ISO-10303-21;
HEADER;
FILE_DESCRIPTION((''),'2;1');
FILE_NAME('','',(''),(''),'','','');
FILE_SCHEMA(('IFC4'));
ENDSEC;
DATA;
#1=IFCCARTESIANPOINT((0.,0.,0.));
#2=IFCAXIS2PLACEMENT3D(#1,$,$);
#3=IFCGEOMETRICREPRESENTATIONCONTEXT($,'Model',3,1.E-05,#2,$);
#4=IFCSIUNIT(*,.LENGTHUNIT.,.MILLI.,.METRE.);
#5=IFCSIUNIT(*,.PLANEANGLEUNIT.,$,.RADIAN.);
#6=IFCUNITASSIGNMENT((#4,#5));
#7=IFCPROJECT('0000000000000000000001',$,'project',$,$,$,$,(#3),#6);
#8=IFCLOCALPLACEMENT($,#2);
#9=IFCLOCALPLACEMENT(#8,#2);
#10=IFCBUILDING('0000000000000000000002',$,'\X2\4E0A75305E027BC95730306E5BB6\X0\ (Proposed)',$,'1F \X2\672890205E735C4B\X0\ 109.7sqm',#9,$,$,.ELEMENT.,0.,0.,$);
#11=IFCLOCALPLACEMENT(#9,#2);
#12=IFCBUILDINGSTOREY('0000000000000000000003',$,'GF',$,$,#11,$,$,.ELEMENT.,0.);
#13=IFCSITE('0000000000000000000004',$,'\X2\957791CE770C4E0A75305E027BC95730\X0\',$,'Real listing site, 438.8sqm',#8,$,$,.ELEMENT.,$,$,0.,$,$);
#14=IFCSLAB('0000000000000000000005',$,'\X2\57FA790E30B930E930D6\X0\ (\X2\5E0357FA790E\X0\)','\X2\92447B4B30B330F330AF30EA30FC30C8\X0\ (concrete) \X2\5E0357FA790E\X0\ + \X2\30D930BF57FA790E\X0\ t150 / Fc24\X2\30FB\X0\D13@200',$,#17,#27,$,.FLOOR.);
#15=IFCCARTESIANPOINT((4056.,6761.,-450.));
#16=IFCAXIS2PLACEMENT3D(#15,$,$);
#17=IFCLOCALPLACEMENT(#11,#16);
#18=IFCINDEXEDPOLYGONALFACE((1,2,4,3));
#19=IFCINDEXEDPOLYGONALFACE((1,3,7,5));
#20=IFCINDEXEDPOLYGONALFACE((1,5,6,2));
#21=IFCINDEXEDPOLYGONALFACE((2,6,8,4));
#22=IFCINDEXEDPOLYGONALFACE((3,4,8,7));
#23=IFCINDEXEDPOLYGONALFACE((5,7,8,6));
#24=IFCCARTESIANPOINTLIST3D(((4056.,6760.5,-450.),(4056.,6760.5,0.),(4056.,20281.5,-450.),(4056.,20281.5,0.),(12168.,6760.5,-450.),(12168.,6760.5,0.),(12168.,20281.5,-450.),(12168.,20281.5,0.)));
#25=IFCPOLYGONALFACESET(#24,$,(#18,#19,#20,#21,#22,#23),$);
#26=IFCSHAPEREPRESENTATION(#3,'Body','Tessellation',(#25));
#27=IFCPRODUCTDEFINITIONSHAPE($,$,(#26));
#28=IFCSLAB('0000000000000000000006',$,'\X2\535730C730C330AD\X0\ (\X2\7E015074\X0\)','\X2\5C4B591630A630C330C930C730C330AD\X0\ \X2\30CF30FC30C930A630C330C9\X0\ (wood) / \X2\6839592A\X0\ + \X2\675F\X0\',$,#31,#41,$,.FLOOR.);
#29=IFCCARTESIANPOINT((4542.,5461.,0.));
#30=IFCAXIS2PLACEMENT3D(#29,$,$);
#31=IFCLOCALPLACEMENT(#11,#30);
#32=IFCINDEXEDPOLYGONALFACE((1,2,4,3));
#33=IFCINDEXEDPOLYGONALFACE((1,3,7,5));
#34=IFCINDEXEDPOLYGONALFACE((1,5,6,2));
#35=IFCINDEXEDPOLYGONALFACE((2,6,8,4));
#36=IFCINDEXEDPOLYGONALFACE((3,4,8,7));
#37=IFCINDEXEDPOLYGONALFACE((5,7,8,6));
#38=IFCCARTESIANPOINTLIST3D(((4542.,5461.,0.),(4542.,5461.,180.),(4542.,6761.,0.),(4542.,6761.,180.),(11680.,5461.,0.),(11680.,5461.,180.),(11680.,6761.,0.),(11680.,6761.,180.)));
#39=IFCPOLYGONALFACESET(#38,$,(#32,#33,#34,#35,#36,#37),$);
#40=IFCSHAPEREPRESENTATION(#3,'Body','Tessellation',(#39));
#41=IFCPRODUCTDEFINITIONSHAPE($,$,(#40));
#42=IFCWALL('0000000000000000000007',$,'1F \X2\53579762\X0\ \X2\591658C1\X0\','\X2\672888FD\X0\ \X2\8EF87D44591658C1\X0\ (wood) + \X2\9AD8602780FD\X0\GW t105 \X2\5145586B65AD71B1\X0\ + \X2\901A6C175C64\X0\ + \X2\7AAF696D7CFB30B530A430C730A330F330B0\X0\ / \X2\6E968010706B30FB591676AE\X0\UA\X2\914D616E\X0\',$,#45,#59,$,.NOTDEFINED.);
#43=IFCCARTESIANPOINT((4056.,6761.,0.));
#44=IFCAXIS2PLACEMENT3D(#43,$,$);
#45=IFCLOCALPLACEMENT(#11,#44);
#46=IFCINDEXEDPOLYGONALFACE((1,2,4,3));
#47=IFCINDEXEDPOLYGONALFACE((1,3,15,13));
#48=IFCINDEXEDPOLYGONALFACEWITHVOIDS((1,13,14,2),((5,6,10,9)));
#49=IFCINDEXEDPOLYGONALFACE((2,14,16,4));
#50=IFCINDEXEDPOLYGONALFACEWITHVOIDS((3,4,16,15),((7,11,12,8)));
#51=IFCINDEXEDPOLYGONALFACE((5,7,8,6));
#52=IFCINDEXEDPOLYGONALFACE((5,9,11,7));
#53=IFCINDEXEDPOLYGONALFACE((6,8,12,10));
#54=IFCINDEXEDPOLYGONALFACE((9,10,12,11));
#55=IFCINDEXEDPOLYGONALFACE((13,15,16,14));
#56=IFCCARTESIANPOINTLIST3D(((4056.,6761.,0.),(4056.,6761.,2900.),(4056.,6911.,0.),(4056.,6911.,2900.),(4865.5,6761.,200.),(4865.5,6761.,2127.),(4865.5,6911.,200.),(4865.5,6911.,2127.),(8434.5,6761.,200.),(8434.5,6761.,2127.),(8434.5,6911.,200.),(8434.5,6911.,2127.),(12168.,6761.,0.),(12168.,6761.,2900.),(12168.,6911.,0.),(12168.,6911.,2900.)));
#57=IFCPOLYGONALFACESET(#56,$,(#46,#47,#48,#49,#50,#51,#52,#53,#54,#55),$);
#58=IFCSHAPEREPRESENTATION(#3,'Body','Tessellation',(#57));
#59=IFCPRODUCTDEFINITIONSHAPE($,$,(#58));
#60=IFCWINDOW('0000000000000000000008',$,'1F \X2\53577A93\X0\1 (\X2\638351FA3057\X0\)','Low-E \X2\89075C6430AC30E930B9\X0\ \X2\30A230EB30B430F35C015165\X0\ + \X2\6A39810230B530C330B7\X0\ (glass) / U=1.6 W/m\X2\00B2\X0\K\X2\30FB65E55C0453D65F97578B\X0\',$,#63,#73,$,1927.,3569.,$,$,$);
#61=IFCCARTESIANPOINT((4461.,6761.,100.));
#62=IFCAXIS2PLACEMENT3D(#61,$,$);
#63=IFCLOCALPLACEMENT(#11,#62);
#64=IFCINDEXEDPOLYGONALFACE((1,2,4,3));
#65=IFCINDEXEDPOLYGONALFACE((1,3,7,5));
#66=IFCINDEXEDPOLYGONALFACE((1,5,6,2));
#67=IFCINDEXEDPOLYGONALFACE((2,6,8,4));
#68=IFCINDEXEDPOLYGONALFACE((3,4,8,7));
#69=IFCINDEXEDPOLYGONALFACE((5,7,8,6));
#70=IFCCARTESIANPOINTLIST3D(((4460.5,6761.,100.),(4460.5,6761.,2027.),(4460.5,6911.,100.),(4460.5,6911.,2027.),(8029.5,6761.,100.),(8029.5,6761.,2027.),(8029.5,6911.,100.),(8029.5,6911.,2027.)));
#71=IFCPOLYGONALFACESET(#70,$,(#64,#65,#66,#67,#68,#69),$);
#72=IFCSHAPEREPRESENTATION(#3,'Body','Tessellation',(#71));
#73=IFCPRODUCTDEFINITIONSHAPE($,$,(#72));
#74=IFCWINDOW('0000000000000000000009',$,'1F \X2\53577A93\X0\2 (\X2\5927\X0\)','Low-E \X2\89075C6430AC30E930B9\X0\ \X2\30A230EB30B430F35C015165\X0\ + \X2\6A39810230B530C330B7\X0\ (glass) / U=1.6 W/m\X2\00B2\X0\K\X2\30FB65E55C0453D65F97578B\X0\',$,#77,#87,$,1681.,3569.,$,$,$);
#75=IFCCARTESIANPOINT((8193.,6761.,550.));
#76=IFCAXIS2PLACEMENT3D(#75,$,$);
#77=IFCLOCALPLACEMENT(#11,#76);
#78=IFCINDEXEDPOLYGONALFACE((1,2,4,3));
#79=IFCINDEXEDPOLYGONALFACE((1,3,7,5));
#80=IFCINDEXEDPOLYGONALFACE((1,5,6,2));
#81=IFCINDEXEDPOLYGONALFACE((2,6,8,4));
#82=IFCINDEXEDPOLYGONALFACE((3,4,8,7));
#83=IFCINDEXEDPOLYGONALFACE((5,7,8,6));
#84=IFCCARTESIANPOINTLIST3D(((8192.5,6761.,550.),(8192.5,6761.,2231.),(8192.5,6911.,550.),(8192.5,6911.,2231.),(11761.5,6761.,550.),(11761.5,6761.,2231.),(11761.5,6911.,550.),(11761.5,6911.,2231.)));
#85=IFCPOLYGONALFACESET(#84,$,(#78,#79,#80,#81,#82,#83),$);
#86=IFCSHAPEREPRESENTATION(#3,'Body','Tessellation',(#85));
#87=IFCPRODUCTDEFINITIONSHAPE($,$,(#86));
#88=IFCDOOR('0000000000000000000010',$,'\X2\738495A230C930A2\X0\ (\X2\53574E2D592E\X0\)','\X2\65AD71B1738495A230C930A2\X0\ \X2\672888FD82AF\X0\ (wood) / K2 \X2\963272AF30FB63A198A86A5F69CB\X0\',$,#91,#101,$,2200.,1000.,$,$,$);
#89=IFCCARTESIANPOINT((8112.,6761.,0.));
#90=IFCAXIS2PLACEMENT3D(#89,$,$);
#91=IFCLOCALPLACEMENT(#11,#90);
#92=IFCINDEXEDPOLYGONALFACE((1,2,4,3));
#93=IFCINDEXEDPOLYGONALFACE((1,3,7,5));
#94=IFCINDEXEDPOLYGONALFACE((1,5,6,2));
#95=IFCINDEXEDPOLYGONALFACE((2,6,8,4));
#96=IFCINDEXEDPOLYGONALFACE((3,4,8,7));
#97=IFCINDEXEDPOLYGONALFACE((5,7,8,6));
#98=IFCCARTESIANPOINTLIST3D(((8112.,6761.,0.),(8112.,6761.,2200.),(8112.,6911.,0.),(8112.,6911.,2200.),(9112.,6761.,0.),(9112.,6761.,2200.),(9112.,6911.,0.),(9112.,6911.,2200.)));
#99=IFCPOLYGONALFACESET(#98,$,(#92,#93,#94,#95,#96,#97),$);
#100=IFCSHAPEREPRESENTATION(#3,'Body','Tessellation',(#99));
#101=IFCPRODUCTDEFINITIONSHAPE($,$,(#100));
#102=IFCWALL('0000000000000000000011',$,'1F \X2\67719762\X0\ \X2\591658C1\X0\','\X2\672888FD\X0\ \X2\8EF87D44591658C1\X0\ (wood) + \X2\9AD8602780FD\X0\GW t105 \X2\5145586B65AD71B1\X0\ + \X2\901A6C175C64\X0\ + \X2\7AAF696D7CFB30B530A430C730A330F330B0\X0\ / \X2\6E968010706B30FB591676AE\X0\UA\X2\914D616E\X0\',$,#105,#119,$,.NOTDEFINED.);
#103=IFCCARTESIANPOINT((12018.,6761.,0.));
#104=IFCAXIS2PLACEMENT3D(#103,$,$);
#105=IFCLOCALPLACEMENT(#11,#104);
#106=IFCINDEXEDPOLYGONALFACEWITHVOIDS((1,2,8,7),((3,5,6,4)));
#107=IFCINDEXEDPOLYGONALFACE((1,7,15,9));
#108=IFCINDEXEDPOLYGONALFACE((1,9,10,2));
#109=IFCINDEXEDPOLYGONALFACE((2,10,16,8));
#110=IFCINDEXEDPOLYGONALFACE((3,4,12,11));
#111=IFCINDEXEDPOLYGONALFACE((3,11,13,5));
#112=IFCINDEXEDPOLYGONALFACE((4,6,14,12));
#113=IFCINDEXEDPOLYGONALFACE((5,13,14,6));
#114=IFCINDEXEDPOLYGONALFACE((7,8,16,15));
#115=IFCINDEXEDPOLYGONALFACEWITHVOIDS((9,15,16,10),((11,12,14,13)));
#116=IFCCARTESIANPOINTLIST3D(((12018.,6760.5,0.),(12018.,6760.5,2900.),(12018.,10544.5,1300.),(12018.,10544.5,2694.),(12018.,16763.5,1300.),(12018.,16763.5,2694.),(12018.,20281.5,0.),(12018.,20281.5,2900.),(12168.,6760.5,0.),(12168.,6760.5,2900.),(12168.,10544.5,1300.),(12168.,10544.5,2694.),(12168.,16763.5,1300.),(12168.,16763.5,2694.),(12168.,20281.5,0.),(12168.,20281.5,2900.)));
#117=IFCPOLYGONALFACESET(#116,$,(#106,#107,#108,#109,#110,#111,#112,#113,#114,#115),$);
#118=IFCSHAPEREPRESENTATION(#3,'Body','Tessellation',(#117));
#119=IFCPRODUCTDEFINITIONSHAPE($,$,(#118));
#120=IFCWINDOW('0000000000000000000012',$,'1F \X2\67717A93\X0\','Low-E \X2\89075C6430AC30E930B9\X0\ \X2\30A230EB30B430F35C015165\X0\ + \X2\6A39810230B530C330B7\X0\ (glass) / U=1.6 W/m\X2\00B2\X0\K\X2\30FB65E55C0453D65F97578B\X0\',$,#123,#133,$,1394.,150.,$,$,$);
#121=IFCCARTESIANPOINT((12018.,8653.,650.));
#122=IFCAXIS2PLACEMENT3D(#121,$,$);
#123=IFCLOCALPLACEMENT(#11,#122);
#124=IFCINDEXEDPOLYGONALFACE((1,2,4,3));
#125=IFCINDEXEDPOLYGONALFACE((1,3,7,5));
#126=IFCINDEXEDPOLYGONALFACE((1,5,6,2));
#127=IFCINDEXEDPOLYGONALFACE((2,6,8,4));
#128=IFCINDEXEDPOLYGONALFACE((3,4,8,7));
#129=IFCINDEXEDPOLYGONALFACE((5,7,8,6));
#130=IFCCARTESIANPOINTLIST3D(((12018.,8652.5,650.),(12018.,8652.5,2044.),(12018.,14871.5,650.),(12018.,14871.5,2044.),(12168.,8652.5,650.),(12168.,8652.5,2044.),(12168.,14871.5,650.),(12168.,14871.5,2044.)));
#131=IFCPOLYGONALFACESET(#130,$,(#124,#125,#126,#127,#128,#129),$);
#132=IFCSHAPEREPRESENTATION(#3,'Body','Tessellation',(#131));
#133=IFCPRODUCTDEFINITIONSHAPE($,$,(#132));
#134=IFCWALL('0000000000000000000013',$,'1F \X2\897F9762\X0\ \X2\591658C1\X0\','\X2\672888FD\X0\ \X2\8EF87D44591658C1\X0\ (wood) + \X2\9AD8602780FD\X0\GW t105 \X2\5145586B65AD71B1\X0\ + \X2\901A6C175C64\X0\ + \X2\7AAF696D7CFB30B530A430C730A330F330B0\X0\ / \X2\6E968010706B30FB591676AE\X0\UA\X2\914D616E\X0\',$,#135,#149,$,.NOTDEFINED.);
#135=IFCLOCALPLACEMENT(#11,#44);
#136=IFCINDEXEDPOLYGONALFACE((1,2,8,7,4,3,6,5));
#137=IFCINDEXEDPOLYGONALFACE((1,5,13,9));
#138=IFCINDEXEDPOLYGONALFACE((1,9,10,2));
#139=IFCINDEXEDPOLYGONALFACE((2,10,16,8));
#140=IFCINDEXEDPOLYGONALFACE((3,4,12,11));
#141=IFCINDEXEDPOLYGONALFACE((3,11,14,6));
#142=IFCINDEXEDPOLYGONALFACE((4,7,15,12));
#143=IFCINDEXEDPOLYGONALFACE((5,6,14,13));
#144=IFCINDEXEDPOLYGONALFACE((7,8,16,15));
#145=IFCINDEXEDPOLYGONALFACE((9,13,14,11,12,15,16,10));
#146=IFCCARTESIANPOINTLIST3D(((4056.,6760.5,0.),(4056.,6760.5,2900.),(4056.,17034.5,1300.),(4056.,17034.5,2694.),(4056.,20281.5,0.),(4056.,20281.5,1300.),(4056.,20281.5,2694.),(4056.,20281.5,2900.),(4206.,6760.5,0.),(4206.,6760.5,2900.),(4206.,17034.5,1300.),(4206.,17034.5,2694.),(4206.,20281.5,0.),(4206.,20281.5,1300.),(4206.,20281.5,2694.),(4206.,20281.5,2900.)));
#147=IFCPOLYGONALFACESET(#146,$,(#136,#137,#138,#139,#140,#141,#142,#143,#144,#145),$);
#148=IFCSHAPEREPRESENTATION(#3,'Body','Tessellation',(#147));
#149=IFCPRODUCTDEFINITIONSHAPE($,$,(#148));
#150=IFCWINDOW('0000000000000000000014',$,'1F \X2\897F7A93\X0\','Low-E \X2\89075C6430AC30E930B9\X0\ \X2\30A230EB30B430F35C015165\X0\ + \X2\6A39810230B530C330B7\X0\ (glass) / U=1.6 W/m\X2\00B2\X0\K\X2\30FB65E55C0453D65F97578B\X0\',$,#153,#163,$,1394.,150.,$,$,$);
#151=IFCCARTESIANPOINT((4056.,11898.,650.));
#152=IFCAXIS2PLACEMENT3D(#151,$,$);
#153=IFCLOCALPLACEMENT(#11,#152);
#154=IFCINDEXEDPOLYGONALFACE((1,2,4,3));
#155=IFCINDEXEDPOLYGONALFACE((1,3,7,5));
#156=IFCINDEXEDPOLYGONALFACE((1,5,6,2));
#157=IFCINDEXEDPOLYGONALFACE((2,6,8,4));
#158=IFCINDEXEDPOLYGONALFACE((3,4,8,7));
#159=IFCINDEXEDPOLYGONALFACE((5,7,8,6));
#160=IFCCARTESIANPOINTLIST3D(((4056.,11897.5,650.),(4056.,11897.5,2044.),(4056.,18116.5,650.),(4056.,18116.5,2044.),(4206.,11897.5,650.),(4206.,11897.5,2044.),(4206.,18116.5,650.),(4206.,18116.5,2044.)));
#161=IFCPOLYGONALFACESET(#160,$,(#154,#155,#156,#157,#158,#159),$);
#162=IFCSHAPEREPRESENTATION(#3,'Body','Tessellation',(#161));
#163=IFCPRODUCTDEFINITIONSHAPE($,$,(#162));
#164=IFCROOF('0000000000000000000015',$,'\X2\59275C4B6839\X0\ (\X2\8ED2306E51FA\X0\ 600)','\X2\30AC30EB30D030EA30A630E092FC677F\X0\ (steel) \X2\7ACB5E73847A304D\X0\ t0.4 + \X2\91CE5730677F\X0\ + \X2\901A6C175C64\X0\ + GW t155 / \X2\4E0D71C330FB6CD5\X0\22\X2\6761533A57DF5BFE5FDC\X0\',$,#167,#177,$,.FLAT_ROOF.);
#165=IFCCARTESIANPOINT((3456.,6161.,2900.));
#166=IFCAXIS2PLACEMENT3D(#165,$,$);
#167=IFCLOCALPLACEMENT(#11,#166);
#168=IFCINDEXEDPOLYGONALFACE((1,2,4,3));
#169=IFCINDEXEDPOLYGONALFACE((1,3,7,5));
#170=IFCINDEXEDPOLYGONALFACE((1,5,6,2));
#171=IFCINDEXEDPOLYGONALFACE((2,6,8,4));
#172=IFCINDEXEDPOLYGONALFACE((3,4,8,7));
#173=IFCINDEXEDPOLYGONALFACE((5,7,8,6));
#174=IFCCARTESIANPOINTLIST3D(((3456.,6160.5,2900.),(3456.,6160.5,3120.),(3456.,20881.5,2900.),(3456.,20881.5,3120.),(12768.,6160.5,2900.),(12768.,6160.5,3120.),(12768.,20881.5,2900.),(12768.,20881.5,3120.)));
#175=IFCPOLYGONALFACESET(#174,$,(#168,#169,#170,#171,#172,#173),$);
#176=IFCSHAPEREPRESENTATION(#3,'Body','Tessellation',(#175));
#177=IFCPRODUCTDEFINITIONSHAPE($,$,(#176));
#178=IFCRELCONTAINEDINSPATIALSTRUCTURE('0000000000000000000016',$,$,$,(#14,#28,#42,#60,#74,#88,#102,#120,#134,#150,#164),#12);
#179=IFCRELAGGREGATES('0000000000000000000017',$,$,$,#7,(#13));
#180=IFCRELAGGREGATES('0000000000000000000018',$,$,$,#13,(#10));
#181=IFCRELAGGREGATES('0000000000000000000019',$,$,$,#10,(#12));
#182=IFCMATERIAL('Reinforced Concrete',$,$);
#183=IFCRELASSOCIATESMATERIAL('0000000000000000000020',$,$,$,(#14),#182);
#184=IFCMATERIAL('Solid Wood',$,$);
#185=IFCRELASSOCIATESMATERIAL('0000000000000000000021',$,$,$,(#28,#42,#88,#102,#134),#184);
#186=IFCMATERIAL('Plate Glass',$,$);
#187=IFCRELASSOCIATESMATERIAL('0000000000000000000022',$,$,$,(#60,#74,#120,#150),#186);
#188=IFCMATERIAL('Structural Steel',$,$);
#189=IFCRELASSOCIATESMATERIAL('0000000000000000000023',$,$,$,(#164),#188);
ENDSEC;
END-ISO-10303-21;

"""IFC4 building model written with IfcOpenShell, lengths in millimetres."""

from ifc_helpers import new_model, si_unit, frame, frame_2d, origin, place, context, project, spatial, rectangle, extrude, material, element, fill, save


model = new_model("IFC4")

# Units and contexts
model_context = context("Model", 3, precision=1e-05, world=origin())
ifc_project = project(units=[si_unit("LENGTHUNIT", "METRE", prefix="MILLI"), si_unit("PLANEANGLEUNIT", "RADIAN")], contexts=[model_context])

# Site, building, storey
site_placement = place(None, origin())
site = spatial("IfcSite", under=ifc_project, at=site_placement, Name="長野県上田市築地", ObjectType="Real listing site, 438.8sqm", CompositionType="ELEMENT", RefElevation=0.0)
building_placement = place(site_placement, origin())
building = spatial("IfcBuilding", under=site, at=building_placement, Name="上田市築地の家 (Proposed)", ObjectType="1F 木造平屋 109.7sqm", CompositionType="ELEMENT", ElevationOfRefHeight=0.0, ElevationOfTerrain=0.0)
storey_placement = place(building_placement, origin())
storey = spatial("IfcBuildingStorey", under=building, at=storey_placement, Name="GF", CompositionType="ELEMENT", Elevation=0.0)

# Slabs
ifc_material_1 = material(Name="Reinforced Concrete")
slab_1_placement = place(storey_placement, frame((4056.0, 6761.0, -450.0)))
element("IfcSlab", 1, at=slab_1_placement, inside=storey, material=ifc_material_1, Name="基礎スラブ (布基礎)", Description="鉄筋コンクリート (concrete) 布基礎 + ベタ基礎 t150 / Fc24・D13@200", PredefinedType="FLOOR", context=model_context, shape_type="SweptSolid", body=[
    extrude(rectangle(XDim=8112.0, YDim=13521.0, at=frame_2d((4056.0, 6760.0))), frame((4056.0, 6761.0, -450.0)), (0.0, 0.0, 1.0), 450.0),
])
ifc_material_2 = material(Name="Solid Wood")
slab_2_placement = place(storey_placement, frame((4542.0, 5461.0, 0.0)))
element("IfcSlab", 2, at=slab_2_placement, inside=storey, material=ifc_material_2, Name="南デッキ (縁側)", Description="屋外ウッドデッキ ハードウッド (wood) / 根太 + 束", PredefinedType="FLOOR", context=model_context, shape_type="SweptSolid", body=[
    extrude(rectangle(XDim=7138.0, YDim=1300.0, at=frame_2d((3569.0, 650.0))), frame((4542.0, 5461.0, 0.0)), (0.0, 0.0, 1.0), 180.0),
])

# Wall, openings, windows, door
wall_1_placement = place(storey_placement, frame((4056.0, 6761.0, 0.0)))
wall_1 = element("IfcWall", 3, at=wall_1_placement, inside=storey, material=ifc_material_2, Name="1F 南面 外壁", Description="木製 軸組外壁 (wood) + 高性能GW t105 充填断熱 + 通気層 + 窯業系サイディング / 準耐火・外皮UA配慮", PredefinedType="NOTDEFINED", context=model_context, shape_type="SweptSolid", body=[
    extrude(rectangle(XDim=8112.0, YDim=150.0, at=frame_2d((4056.0, 75.0))), frame((4056.0, 6761.0, 0.0)), (0.0, 0.0, 1.0), 2900.0),
])
opening_1_placement = place(storey_placement, frame((4461.0, 6761.0, 100.0)))
opening_1 = element("IfcOpeningElement", 4, at=opening_1_placement, cuts=wall_1, PredefinedType="NOTDEFINED", context=model_context, shape_type="SweptSolid", body=[
    extrude(rectangle(XDim=3569.0, YDim=150.0, at=frame_2d((1784.0, 75.0))), frame((4461.0, 6761.0, 100.0)), (0.0, 0.0, 1.0), 1927.0),
])
opening_2_placement = place(storey_placement, frame((8193.0, 6761.0, 550.0)))
opening_2 = element("IfcOpeningElement", 5, at=opening_2_placement, cuts=wall_1, PredefinedType="NOTDEFINED", context=model_context, shape_type="SweptSolid", body=[
    extrude(rectangle(XDim=3569.0, YDim=150.0, at=frame_2d((1784.0, 75.0))), frame((8193.0, 6761.0, 550.0)), (0.0, 0.0, 1.0), 1681.0),
])
opening_3_placement = place(storey_placement, frame((8112.0, 6761.0, 0.0)))
opening_3 = element("IfcOpeningElement", 6, at=opening_3_placement, cuts=wall_1, PredefinedType="NOTDEFINED", context=model_context, shape_type="SweptSolid", body=[
    extrude(rectangle(XDim=1000.0, YDim=150.0, at=frame_2d((500.0, 75.0))), frame((8112.0, 6761.0, 0.0)), (0.0, 0.0, 1.0), 2200.0),
])
ifc_material_3 = material(Name="Plate Glass")
window_1_placement = place(storey_placement, frame((4461.0, 6761.0, 100.0)))
window_1 = element("IfcWindow", 7, at=window_1_placement, inside=storey, material=ifc_material_3, Name="1F 南窓1 (掃出し)", Description="Low-E 複層ガラス アルゴン封入 + 樹脂サッシ (glass) / U=1.6 W/m²K・日射取得型", OverallHeight=1927.0, OverallWidth=3569.0, context=model_context, shape_type="SweptSolid", body=[
    extrude(rectangle(XDim=3569.0, YDim=150.0, at=frame_2d((1784.0, 75.0))), frame((4461.0, 6761.0, 100.0)), (0.0, 0.0, 1.0), 1927.0),
])
fill(opening_1, window_1)
window_2_placement = place(storey_placement, frame((8193.0, 6761.0, 550.0)))
window_2 = element("IfcWindow", 8, at=window_2_placement, inside=storey, material=ifc_material_3, Name="1F 南窓2 (大)", Description="Low-E 複層ガラス アルゴン封入 + 樹脂サッシ (glass) / U=1.6 W/m²K・日射取得型", OverallHeight=1681.0, OverallWidth=3569.0, context=model_context, shape_type="SweptSolid", body=[
    extrude(rectangle(XDim=3569.0, YDim=150.0, at=frame_2d((1784.0, 75.0))), frame((8193.0, 6761.0, 550.0)), (0.0, 0.0, 1.0), 1681.0),
])
fill(opening_2, window_2)
door_placement = place(storey_placement, frame((8112.0, 6761.0, 0.0)))
door = element("IfcDoor", 9, at=door_placement, inside=storey, material=ifc_material_2, Name="玄関ドア (南中央)", Description="断熱玄関ドア 木製芯 (wood) / K2 防犯・採風機構", OverallHeight=2200.0, OverallWidth=1000.0, context=model_context, shape_type="SweptSolid", body=[
    extrude(rectangle(XDim=1000.0, YDim=150.0, at=frame_2d((500.0, 75.0))), frame((8112.0, 6761.0, 0.0)), (0.0, 0.0, 1.0), 2200.0),
])
fill(opening_3, door)

# Walls, openings, windows
wall_2_placement = place(storey_placement, frame((12018.0, 6761.0, 0.0)))
wall_2 = element("IfcWall", 10, at=wall_2_placement, inside=storey, material=ifc_material_2, Name="1F 東面 外壁", Description="木製 軸組外壁 (wood) + 高性能GW t105 充填断熱 + 通気層 + 窯業系サイディング / 準耐火・外皮UA配慮", PredefinedType="NOTDEFINED", context=model_context, shape_type="SweptSolid", body=[
    extrude(rectangle(XDim=150.0, YDim=13521.0, at=frame_2d((75.0, 6760.0))), frame((12018.0, 6761.0, 0.0)), (0.0, 0.0, 1.0), 2900.0),
])
opening_4_placement = place(storey_placement, frame((12018.0, 8653.0, 650.0)))
opening_4 = element("IfcOpeningElement", 11, at=opening_4_placement, cuts=wall_2, PredefinedType="NOTDEFINED", context=model_context, shape_type="SweptSolid", body=[
    extrude(rectangle(XDim=150.0, YDim=6219.0, at=frame_2d((75.0, 3109.0))), frame((12018.0, 8653.0, 650.0)), (0.0, 0.0, 1.0), 1394.0),
])
window_3_placement = place(storey_placement, frame((12018.0, 8653.0, 650.0)))
window_3 = element("IfcWindow", 12, at=window_3_placement, inside=storey, material=ifc_material_3, Name="1F 東窓", Description="Low-E 複層ガラス アルゴン封入 + 樹脂サッシ (glass) / U=1.6 W/m²K・日射取得型", OverallHeight=1394.0, OverallWidth=150.0, context=model_context, shape_type="SweptSolid", body=[
    extrude(rectangle(XDim=150.0, YDim=6219.0, at=frame_2d((75.0, 3109.0))), frame((12018.0, 8653.0, 650.0)), (0.0, 0.0, 1.0), 1394.0),
])
fill(opening_4, window_3)
wall_3_placement = place(storey_placement, frame((4056.0, 6761.0, 0.0)))
wall_3 = element("IfcWall", 13, at=wall_3_placement, inside=storey, material=ifc_material_2, Name="1F 西面 外壁", Description="木製 軸組外壁 (wood) + 高性能GW t105 充填断熱 + 通気層 + 窯業系サイディング / 準耐火・外皮UA配慮", PredefinedType="NOTDEFINED", context=model_context, shape_type="SweptSolid", body=[
    extrude(rectangle(XDim=150.0, YDim=13521.0, at=frame_2d((75.0, 6760.0))), frame((4056.0, 6761.0, 0.0)), (0.0, 0.0, 1.0), 2900.0),
])
opening_5_placement = place(storey_placement, frame((4056.0, 11898.0, 650.0)))
opening_5 = element("IfcOpeningElement", 14, at=opening_5_placement, cuts=wall_3, PredefinedType="NOTDEFINED", context=model_context, shape_type="SweptSolid", body=[
    extrude(rectangle(XDim=150.0, YDim=6219.0, at=frame_2d((75.0, 3109.0))), frame((4056.0, 11898.0, 650.0)), (0.0, 0.0, 1.0), 1394.0),
])
window_4_placement = place(storey_placement, frame((4056.0, 11898.0, 650.0)))
window_4 = element("IfcWindow", 15, at=window_4_placement, inside=storey, material=ifc_material_3, Name="1F 西窓", Description="Low-E 複層ガラス アルゴン封入 + 樹脂サッシ (glass) / U=1.6 W/m²K・日射取得型", OverallHeight=1394.0, OverallWidth=150.0, context=model_context, shape_type="SweptSolid", body=[
    extrude(rectangle(XDim=150.0, YDim=6219.0, at=frame_2d((75.0, 3109.0))), frame((4056.0, 11898.0, 650.0)), (0.0, 0.0, 1.0), 1394.0),
])
fill(opening_5, window_4)

# Roof
ifc_material_4 = material(Name="Structural Steel")
roof_placement = place(storey_placement, frame((3456.0, 6161.0, 2900.0)))
element("IfcRoof", 16, at=roof_placement, inside=storey, material=ifc_material_4, Name="大屋根 (軒の出 600)", Description="ガルバリウム鋼板 (steel) 立平葺き t0.4 + 野地板 + 通気層 + GW t155 / 不燃・法22条区域対応", PredefinedType="FLAT_ROOF", context=model_context, shape_type="SweptSolid", body=[
    extrude(rectangle(XDim=9312.0, YDim=14721.0, at=frame_2d((4656.0, 7360.0))), frame((3456.0, 6161.0, 2900.0)), (0.0, 0.0, 1.0), 220.0),
])

save(model, "model.ifc")
